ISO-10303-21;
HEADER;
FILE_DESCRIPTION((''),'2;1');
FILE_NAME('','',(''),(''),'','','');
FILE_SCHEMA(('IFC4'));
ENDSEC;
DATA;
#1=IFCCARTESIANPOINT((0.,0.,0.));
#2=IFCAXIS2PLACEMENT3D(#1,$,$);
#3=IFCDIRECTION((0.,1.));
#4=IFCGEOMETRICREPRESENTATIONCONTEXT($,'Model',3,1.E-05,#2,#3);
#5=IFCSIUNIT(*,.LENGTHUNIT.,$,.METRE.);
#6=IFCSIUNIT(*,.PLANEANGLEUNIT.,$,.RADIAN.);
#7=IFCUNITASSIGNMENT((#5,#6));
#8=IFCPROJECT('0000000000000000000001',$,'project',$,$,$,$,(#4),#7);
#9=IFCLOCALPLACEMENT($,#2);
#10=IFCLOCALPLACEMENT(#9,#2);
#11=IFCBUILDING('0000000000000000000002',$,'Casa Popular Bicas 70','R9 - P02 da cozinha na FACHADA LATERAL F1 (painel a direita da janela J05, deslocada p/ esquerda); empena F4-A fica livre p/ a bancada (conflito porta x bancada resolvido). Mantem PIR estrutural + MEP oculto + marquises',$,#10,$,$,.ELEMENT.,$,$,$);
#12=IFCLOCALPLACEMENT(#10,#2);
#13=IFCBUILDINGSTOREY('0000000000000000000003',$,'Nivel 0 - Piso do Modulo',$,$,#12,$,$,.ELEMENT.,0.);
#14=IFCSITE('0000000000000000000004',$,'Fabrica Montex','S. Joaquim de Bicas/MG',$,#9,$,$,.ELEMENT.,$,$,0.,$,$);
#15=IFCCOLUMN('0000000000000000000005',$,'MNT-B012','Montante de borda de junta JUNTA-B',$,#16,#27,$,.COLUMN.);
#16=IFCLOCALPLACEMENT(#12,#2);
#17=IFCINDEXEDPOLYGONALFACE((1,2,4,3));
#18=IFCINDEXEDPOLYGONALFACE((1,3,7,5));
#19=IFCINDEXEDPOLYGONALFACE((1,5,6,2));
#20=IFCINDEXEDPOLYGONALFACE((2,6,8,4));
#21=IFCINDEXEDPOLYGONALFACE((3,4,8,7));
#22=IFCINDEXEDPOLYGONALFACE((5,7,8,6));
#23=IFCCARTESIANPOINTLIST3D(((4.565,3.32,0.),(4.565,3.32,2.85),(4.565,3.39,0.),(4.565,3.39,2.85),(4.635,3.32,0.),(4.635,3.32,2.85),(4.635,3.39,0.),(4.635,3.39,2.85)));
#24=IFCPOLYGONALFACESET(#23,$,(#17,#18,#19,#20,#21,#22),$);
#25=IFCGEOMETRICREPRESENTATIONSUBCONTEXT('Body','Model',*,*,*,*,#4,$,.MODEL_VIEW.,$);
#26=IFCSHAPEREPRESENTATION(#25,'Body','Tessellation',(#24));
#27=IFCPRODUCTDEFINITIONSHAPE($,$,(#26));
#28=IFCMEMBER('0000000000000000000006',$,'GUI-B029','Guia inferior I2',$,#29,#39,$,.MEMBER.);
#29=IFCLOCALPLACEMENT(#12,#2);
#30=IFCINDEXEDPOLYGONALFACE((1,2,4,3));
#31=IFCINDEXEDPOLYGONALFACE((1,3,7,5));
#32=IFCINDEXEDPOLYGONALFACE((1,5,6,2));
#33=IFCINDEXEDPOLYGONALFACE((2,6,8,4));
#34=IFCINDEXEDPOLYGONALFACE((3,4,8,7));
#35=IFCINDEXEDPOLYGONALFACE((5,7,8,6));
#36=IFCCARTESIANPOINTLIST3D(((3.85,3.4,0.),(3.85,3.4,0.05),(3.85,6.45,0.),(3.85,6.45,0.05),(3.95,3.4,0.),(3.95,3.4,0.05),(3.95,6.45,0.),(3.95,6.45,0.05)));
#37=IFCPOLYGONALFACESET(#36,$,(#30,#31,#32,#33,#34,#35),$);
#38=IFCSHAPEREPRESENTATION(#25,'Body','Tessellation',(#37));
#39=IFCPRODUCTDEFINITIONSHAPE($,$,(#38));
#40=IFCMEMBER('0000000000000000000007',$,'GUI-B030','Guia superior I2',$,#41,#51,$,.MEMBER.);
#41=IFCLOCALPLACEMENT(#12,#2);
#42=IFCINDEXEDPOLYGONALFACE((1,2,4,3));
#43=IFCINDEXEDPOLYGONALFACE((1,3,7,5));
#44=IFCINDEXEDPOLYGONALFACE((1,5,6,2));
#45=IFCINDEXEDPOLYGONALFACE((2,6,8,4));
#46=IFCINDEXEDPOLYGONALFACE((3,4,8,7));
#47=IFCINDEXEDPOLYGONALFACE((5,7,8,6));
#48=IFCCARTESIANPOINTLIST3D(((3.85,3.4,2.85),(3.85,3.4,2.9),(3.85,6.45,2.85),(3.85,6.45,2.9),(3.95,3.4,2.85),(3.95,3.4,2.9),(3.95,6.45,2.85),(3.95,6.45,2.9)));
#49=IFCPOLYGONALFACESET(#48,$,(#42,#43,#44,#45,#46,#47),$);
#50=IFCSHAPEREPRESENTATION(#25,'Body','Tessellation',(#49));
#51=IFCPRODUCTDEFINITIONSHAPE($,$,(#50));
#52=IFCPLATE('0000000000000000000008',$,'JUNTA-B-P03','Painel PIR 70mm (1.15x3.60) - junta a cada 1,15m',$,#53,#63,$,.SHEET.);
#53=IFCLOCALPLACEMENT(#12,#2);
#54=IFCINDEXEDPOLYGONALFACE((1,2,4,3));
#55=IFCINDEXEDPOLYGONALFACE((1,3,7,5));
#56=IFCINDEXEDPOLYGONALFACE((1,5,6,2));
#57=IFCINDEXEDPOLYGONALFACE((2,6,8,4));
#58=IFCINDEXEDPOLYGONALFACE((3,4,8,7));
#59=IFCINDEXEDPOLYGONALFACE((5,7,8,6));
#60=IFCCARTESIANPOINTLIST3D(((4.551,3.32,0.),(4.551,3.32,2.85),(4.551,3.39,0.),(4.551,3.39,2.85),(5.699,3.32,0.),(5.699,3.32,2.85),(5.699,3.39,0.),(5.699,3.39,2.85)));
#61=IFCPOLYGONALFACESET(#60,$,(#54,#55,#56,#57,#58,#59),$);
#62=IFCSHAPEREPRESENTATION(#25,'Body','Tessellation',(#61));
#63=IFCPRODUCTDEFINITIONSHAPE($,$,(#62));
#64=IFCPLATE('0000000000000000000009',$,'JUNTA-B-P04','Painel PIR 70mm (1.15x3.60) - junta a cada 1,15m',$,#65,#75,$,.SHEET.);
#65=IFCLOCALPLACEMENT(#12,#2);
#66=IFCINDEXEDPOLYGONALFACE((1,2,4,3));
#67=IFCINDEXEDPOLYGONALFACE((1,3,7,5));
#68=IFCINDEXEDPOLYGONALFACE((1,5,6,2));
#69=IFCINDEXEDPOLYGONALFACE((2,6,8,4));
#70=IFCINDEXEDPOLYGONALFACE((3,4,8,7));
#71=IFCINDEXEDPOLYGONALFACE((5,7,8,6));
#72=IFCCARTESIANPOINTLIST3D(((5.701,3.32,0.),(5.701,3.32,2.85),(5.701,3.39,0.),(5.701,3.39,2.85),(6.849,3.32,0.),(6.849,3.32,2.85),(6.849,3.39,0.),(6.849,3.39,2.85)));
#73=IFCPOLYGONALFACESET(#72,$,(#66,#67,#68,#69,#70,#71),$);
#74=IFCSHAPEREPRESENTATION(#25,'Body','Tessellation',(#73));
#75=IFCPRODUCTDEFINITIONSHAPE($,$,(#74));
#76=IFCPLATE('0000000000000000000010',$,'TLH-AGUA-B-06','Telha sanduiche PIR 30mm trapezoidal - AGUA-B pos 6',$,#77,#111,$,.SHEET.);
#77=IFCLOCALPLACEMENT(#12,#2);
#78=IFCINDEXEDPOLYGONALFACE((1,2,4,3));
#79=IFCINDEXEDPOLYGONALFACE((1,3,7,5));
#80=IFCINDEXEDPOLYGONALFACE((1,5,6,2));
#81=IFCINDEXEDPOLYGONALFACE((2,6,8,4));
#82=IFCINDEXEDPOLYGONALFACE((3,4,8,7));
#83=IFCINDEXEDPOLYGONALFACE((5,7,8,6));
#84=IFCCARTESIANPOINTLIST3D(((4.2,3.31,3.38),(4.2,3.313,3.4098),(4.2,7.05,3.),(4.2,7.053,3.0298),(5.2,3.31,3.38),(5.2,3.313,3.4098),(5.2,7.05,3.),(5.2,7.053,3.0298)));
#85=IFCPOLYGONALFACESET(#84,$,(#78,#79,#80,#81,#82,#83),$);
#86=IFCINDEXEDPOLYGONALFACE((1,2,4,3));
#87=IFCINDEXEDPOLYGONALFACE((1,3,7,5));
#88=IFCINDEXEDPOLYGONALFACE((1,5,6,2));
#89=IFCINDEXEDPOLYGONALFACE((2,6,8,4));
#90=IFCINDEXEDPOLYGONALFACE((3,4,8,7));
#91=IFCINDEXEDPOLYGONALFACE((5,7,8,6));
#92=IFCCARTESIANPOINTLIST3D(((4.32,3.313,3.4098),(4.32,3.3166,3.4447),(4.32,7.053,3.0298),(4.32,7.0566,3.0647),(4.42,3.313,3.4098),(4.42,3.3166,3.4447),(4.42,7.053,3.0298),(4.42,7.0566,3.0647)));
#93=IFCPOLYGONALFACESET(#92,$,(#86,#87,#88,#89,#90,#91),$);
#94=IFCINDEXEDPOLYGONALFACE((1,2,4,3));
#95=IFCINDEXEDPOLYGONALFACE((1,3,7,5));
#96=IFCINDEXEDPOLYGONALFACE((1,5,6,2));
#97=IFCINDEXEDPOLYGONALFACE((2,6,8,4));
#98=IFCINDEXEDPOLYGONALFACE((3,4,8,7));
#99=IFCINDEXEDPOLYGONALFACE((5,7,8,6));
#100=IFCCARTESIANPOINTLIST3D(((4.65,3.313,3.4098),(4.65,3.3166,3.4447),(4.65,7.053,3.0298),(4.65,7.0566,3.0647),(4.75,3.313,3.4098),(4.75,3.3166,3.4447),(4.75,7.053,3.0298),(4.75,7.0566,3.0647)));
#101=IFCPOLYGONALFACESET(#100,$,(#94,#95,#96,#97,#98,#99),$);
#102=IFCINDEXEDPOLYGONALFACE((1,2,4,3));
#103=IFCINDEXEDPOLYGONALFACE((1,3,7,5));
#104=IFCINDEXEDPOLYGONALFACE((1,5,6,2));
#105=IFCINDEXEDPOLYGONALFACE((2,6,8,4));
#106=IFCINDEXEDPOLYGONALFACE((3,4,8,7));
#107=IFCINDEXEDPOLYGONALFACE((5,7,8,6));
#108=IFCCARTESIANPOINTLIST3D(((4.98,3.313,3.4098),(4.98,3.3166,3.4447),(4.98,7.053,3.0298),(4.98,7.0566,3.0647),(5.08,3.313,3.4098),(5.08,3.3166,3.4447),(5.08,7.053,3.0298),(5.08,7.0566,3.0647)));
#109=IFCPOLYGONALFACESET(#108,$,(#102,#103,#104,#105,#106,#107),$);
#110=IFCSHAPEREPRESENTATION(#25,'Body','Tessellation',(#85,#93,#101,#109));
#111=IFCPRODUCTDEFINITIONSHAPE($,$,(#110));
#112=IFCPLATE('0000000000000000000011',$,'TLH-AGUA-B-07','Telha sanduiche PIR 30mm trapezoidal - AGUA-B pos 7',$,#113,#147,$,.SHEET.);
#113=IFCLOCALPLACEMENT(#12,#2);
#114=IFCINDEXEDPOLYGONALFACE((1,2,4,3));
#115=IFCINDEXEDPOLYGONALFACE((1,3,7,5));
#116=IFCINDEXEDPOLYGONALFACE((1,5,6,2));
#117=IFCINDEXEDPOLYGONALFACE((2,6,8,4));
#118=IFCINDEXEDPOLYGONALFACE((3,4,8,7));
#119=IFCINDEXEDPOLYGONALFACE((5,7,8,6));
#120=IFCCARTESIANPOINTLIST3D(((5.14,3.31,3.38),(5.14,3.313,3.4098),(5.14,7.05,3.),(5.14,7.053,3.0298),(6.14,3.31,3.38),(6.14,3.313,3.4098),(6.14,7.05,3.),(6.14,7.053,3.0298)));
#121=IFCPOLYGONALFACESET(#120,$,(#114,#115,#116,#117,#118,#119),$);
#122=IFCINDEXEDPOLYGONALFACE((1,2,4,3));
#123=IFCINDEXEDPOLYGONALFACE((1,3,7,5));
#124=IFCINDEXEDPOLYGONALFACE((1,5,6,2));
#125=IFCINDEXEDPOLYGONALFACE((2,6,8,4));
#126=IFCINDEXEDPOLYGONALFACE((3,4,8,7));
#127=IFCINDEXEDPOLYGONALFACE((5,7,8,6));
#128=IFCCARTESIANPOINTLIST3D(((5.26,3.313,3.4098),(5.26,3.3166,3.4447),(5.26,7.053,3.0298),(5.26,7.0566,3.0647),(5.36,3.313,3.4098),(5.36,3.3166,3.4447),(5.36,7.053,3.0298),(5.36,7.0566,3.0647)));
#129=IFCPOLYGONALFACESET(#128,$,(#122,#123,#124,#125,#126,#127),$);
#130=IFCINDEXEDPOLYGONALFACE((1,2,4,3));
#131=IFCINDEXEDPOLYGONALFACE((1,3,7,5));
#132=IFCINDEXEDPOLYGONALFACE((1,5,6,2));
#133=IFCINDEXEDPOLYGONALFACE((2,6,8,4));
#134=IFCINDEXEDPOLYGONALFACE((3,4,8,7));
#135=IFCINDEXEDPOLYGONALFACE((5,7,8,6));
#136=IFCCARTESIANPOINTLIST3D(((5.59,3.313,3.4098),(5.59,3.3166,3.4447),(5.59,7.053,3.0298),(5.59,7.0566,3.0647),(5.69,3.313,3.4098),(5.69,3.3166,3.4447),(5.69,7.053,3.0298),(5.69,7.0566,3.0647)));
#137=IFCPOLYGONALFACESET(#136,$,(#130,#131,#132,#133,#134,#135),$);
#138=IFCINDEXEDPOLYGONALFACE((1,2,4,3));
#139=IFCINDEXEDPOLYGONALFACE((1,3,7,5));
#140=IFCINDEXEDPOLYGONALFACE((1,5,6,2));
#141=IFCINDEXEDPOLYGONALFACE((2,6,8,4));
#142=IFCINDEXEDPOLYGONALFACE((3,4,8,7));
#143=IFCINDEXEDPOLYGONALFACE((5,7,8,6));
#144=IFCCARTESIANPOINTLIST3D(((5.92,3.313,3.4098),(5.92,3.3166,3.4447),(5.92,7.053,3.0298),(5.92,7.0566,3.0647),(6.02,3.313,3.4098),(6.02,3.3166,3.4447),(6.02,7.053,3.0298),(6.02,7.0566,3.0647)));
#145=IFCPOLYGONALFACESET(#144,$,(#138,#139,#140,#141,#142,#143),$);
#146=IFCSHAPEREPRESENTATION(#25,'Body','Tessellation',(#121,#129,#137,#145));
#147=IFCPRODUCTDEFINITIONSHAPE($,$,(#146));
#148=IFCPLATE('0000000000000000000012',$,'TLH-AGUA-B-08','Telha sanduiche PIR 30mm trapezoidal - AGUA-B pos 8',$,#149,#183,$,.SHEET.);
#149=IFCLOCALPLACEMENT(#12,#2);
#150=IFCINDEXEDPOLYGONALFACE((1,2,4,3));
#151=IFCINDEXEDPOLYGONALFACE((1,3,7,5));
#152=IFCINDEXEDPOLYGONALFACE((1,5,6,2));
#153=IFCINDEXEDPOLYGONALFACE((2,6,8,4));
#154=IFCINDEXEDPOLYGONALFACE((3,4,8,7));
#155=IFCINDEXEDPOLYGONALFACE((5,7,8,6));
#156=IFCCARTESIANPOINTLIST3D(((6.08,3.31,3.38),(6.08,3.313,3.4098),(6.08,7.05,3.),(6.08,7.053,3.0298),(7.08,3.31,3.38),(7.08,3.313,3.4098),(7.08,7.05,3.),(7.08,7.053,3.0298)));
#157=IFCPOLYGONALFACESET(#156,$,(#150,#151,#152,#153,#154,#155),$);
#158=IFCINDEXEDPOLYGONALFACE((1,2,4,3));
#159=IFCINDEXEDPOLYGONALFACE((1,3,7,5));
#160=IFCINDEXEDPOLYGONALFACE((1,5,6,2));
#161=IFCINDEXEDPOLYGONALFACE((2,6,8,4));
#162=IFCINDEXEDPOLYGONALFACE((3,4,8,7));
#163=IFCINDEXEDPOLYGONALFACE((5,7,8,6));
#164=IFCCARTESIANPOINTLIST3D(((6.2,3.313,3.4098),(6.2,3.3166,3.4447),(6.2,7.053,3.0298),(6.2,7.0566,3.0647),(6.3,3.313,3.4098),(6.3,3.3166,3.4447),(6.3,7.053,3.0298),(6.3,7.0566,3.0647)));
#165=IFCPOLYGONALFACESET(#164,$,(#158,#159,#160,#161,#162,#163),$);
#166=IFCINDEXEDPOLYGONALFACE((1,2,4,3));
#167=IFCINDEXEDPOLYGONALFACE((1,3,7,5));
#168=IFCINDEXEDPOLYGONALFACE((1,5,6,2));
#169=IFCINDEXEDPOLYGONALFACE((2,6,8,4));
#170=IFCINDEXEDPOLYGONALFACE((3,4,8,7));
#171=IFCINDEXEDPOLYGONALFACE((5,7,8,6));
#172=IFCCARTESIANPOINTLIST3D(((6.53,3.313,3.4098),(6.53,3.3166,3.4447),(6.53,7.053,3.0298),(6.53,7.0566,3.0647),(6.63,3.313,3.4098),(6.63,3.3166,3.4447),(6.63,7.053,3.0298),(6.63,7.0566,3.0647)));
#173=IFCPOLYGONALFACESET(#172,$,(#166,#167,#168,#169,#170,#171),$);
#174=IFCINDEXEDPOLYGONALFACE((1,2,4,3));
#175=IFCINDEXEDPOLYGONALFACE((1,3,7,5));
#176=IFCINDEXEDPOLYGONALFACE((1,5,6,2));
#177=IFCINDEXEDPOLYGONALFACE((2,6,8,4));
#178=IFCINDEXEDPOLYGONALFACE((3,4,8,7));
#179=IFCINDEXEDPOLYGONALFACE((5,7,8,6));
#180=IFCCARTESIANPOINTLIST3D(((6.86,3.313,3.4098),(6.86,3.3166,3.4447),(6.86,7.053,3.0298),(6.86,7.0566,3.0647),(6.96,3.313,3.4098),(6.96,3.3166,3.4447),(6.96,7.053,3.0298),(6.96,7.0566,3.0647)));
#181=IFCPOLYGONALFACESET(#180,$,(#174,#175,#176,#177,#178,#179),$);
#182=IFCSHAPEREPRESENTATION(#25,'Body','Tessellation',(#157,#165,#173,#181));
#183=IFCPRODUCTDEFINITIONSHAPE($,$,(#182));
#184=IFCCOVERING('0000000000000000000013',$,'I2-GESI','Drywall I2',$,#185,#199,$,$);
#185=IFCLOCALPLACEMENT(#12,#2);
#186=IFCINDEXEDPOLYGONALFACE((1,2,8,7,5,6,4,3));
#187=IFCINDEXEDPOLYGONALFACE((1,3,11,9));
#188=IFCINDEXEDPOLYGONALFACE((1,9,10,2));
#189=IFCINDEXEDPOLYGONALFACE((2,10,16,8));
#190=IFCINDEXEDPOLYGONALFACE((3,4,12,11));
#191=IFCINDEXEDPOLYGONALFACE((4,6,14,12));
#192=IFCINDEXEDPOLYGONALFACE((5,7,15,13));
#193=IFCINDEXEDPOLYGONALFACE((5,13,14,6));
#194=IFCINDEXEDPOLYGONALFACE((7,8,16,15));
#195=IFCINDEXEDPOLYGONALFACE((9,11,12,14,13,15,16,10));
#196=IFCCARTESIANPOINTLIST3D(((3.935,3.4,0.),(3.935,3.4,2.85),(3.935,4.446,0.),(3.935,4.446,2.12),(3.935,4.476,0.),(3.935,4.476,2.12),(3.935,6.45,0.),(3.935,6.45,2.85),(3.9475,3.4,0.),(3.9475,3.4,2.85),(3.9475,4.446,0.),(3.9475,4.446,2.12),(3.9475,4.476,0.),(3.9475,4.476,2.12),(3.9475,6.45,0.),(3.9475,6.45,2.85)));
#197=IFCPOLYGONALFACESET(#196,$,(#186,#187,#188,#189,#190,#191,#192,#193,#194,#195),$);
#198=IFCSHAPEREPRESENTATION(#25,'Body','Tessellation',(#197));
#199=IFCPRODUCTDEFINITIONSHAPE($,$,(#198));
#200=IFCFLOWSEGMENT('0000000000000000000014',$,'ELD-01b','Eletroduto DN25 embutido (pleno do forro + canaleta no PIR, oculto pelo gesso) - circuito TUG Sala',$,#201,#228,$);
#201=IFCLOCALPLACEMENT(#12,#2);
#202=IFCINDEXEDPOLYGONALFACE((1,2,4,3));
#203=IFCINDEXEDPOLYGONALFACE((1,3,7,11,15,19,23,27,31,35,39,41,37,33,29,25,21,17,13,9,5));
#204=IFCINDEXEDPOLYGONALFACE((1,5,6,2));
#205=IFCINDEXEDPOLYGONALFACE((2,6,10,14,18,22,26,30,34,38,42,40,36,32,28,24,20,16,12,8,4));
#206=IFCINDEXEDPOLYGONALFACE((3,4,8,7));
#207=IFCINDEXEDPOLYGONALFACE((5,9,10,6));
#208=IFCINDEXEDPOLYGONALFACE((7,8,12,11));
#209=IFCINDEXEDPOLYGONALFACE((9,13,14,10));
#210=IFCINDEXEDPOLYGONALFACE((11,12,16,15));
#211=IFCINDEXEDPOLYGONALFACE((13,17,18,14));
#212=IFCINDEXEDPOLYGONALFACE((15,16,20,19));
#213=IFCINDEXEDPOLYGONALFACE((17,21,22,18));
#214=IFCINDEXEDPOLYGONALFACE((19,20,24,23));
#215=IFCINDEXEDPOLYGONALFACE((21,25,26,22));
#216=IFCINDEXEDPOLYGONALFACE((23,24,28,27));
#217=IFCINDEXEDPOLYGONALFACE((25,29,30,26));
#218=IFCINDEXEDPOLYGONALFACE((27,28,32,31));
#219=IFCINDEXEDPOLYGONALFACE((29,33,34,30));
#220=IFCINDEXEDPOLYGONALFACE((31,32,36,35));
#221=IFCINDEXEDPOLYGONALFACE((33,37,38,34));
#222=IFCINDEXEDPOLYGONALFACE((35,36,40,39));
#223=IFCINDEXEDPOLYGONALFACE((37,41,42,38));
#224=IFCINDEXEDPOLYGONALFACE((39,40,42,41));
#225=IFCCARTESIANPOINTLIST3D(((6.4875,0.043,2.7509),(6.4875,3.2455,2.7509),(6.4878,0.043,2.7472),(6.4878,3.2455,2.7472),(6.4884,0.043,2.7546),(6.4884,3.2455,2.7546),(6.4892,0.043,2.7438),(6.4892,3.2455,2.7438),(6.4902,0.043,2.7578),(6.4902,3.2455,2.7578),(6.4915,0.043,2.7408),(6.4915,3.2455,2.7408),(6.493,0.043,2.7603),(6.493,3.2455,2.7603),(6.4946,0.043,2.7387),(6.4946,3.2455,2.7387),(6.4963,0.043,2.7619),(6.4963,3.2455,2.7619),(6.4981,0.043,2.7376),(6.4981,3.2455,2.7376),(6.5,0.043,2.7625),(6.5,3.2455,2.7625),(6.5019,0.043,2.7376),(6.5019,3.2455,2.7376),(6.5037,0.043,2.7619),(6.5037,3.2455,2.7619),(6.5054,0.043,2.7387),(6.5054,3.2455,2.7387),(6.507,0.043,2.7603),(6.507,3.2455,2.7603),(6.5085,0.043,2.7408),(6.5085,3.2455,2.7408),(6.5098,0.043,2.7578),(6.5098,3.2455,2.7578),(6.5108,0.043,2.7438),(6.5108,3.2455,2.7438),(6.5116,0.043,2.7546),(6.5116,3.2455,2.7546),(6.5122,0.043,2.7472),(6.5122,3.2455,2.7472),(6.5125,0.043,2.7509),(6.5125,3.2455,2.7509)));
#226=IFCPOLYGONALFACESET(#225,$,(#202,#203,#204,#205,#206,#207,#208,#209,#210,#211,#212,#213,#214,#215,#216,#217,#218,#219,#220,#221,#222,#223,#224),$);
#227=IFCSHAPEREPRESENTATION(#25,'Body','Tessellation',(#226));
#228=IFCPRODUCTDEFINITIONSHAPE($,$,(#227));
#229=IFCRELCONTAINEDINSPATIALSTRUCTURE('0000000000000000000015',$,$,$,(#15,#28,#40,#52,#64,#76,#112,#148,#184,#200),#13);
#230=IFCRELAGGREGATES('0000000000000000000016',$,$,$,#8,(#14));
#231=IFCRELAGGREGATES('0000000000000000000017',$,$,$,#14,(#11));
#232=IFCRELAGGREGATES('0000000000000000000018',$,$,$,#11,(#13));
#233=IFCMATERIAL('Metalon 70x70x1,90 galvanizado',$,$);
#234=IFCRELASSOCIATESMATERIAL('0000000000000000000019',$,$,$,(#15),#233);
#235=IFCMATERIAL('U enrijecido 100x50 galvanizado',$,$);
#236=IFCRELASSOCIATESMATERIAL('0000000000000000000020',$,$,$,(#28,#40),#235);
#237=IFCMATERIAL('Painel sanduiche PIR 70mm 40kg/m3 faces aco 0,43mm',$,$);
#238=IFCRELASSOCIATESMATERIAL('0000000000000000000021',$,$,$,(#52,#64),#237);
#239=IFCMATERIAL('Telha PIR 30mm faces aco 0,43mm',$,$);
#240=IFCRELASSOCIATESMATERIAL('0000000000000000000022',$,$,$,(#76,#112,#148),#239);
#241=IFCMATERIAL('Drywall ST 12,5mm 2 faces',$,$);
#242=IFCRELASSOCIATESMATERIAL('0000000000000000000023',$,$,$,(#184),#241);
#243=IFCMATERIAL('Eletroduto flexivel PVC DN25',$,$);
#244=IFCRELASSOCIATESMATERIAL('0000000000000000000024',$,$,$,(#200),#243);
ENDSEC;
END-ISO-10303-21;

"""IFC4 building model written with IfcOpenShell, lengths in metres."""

from ifc_helpers import new_model, si_unit, direction, frame, frame_2d, origin, origin_2d, place, context, subcontext, project, spatial, rectangle, circle, extrude, material, element, save


model = new_model("IFC4")

# Units and contexts
model_context = context("Model", 3, precision=1e-05, world=origin(), true_north=direction((0.0, 1.0)))
body_context = subcontext(model_context, "Body", "Model", "MODEL_VIEW")
ifc_project = project(units=[si_unit("LENGTHUNIT", "METRE"), si_unit("PLANEANGLEUNIT", "RADIAN")], contexts=[model_context])

# Site, building, storey
site_placement = place(None, origin())
site = spatial("IfcSite", under=ifc_project, at=site_placement, Name="Fabrica Montex", Description="S. Joaquim de Bicas/MG", CompositionType="ELEMENT", RefElevation=0.0)
building_placement = place(site_placement, origin())
building = spatial("IfcBuilding", under=site, at=building_placement, Name="Casa Popular Bicas 70", Description="R9 - P02 da cozinha na FACHADA LATERAL F1 (painel a direita da janela J05, deslocada p/ esquerda); empena F4-A fica livre p/ a bancada (conflito porta x bancada resolvido). Mantem PIR estrutural + MEP oculto + marquises", CompositionType="ELEMENT")
storey_placement = place(building_placement, origin())
storey = spatial("IfcBuildingStorey", under=building, at=storey_placement, Name="Nivel 0 - Piso do Modulo", CompositionType="ELEMENT", Elevation=0.0)

# Column
ifc_material_1 = material(Name="Metalon 70x70x1,90 galvanizado")
column_placement = place(storey_placement, frame((4.6, 3.355, 0.0)))
element("IfcColumn", 1, at=column_placement, inside=storey, material=ifc_material_1, Name="MNT-B012", Description="Montante de borda de junta JUNTA-B", PredefinedType="COLUMN", context=body_context, shape_type="SweptSolid", body=[
    extrude(rectangle(XDim=0.07, YDim=0.07, at=origin_2d()), origin(), (0.0, 0.0, 1.0), 2.85),
])

# Members
ifc_material_2 = material(Name="U enrijecido 100x50 galvanizado")
for number, where, z_axis, x_axis, name, description in (
    (2, (3.9, 3.4, 0.025), (0.0, 1.0, 0.0), (0.0, 0.0, 1.0), "GUI-B029", "Guia inferior I2"),
    (3, (3.9, 3.4, 2.875), (0.0, 1.0, 0.0), (0.0, 0.0, 1.0), "GUI-B030", "Guia superior I2"),
):
    element("IfcMember", number, at=place(storey_placement, frame(where, z_axis=z_axis, x_axis=x_axis)), inside=storey, material=ifc_material_2, Name=name, Description=description, PredefinedType="MEMBER", context=body_context, shape_type="SweptSolid", body=[
        extrude(rectangle(XDim=0.05, YDim=0.1, at=origin_2d()), origin(), (0.0, 0.0, 1.0), 3.05),
    ])

# Plates
ifc_material_3 = material(Name="Painel sanduiche PIR 70mm 40kg/m3 faces aco 0,43mm")
for number, where, x_axis, name in (
    (4, (4.551, 3.355, 0.0), (1.0, 0.0, 0.0), "JUNTA-B-P03"),
    (5, (5.701, 3.355, 0.0), (1.0, 0.0, 0.0), "JUNTA-B-P04"),
):
    element("IfcPlate", number, at=place(storey_placement, frame(where, x_axis=x_axis)), inside=storey, material=ifc_material_3, Name=name, Description="Painel PIR 70mm (1.15x3.60) - junta a cada 1,15m", PredefinedType="SHEET", context=body_context, shape_type="SweptSolid", body=[
        extrude(rectangle(XDim=1.148, YDim=0.07, at=frame_2d((0.574, 0.0))), origin(), (0.0, 0.0, 1.0), 2.85),
    ])
ifc_material_4 = material(Name="Telha PIR 30mm faces aco 0,43mm")
for number, where, z_axis, x_axis, name, description in (
    (6, (4.2, 3.31, 3.38), (0.0, 0.101084, 0.994878), (1.0, 0.0, 0.0), "TLH-AGUA-B-06", "Telha sanduiche PIR 30mm trapezoidal - AGUA-B pos 6"),
    (7, (5.14, 3.31, 3.38), (0.0, 0.101084, 0.994878), (1.0, 0.0, 0.0), "TLH-AGUA-B-07", "Telha sanduiche PIR 30mm trapezoidal - AGUA-B pos 7"),
    (8, (6.08, 3.31, 3.38), (0.0, 0.101084, 0.994878), (1.0, 0.0, 0.0), "TLH-AGUA-B-08", "Telha sanduiche PIR 30mm trapezoidal - AGUA-B pos 8"),
):
    element("IfcPlate", number, at=place(storey_placement, frame(where, z_axis=z_axis, x_axis=x_axis)), inside=storey, material=ifc_material_4, Name=name, Description=description, PredefinedType="SHEET", context=body_context, shape_type="SweptSolid", body=[
        extrude(rectangle(XDim=1.0, YDim=3.7593, at=frame_2d((0.5, 1.8796))), origin(), (0.0, 0.0, 1.0), 0.03),
        extrude(rectangle(XDim=0.1, YDim=3.7593, at=frame_2d((0.17, 1.8796))), frame((0.0, 0.0, 0.03)), (0.0, 0.0, 1.0), 0.035),
        extrude(rectangle(XDim=0.1, YDim=3.7593, at=frame_2d((0.5, 1.8796))), frame((0.0, 0.0, 0.03)), (0.0, 0.0, 1.0), 0.035),
        extrude(rectangle(XDim=0.1, YDim=3.7593, at=frame_2d((0.83, 1.8796))), frame((0.0, 0.0, 0.03)), (0.0, 0.0, 1.0), 0.035),
    ])

# Covering, opening
ifc_material_5 = material(Name="Drywall ST 12,5mm 2 faces")
covering_1_placement = place(storey_placement, frame((3.9412, 3.4, 0.0), x_axis=(0.0, 1.0, 0.0)))
covering_1 = element("IfcCovering", 9, at=covering_1_placement, inside=storey, material=ifc_material_5, Name="I2-GESI", Description="Drywall I2", context=body_context, shape_type="SweptSolid", body=[
    extrude(rectangle(XDim=3.05, YDim=0.0125, at=frame_2d((1.525, 0.0))), origin(), (0.0, 0.0, 1.0), 2.85),
])
opening_1_placement = place(storey_placement, frame((3.925, 4.461, 0.0)))
element("IfcOpeningElement", 10, at=opening_1_placement, cuts=covering_1, PredefinedType="OPENING", context=body_context, shape_type="SweptSolid", body=[
    extrude(rectangle(XDim=0.82, YDim=0.03, at=frame_2d((0.4, 0.0))), origin(), (0.0, 0.0, 1.0), 2.12),
])

# Flow segment
ifc_material_6 = material(Name="Eletroduto flexivel PVC DN25")
for number, where, z_axis, x_axis, name in (
    (11, (6.5, 3.2455, 2.75), (0.0, -1.0, 0.0), (0.0, 0.0, 1.0), "ELD-01b"),
):
    element("IfcFlowSegment", number, at=place(storey_placement, frame(where, z_axis=z_axis, x_axis=x_axis)), inside=storey, material=ifc_material_6, Name=name, Description="Eletroduto DN25 embutido (pleno do forro + canaleta no PIR, oculto pelo gesso) - circuito TUG Sala", context=body_context, shape_type="SweptSolid", body=[
        extrude(circle(Radius=0.0125, at=origin_2d()), origin(), (0.0, 0.0, 1.0), 3.2025),
    ])

save(model, "model.ifc")
